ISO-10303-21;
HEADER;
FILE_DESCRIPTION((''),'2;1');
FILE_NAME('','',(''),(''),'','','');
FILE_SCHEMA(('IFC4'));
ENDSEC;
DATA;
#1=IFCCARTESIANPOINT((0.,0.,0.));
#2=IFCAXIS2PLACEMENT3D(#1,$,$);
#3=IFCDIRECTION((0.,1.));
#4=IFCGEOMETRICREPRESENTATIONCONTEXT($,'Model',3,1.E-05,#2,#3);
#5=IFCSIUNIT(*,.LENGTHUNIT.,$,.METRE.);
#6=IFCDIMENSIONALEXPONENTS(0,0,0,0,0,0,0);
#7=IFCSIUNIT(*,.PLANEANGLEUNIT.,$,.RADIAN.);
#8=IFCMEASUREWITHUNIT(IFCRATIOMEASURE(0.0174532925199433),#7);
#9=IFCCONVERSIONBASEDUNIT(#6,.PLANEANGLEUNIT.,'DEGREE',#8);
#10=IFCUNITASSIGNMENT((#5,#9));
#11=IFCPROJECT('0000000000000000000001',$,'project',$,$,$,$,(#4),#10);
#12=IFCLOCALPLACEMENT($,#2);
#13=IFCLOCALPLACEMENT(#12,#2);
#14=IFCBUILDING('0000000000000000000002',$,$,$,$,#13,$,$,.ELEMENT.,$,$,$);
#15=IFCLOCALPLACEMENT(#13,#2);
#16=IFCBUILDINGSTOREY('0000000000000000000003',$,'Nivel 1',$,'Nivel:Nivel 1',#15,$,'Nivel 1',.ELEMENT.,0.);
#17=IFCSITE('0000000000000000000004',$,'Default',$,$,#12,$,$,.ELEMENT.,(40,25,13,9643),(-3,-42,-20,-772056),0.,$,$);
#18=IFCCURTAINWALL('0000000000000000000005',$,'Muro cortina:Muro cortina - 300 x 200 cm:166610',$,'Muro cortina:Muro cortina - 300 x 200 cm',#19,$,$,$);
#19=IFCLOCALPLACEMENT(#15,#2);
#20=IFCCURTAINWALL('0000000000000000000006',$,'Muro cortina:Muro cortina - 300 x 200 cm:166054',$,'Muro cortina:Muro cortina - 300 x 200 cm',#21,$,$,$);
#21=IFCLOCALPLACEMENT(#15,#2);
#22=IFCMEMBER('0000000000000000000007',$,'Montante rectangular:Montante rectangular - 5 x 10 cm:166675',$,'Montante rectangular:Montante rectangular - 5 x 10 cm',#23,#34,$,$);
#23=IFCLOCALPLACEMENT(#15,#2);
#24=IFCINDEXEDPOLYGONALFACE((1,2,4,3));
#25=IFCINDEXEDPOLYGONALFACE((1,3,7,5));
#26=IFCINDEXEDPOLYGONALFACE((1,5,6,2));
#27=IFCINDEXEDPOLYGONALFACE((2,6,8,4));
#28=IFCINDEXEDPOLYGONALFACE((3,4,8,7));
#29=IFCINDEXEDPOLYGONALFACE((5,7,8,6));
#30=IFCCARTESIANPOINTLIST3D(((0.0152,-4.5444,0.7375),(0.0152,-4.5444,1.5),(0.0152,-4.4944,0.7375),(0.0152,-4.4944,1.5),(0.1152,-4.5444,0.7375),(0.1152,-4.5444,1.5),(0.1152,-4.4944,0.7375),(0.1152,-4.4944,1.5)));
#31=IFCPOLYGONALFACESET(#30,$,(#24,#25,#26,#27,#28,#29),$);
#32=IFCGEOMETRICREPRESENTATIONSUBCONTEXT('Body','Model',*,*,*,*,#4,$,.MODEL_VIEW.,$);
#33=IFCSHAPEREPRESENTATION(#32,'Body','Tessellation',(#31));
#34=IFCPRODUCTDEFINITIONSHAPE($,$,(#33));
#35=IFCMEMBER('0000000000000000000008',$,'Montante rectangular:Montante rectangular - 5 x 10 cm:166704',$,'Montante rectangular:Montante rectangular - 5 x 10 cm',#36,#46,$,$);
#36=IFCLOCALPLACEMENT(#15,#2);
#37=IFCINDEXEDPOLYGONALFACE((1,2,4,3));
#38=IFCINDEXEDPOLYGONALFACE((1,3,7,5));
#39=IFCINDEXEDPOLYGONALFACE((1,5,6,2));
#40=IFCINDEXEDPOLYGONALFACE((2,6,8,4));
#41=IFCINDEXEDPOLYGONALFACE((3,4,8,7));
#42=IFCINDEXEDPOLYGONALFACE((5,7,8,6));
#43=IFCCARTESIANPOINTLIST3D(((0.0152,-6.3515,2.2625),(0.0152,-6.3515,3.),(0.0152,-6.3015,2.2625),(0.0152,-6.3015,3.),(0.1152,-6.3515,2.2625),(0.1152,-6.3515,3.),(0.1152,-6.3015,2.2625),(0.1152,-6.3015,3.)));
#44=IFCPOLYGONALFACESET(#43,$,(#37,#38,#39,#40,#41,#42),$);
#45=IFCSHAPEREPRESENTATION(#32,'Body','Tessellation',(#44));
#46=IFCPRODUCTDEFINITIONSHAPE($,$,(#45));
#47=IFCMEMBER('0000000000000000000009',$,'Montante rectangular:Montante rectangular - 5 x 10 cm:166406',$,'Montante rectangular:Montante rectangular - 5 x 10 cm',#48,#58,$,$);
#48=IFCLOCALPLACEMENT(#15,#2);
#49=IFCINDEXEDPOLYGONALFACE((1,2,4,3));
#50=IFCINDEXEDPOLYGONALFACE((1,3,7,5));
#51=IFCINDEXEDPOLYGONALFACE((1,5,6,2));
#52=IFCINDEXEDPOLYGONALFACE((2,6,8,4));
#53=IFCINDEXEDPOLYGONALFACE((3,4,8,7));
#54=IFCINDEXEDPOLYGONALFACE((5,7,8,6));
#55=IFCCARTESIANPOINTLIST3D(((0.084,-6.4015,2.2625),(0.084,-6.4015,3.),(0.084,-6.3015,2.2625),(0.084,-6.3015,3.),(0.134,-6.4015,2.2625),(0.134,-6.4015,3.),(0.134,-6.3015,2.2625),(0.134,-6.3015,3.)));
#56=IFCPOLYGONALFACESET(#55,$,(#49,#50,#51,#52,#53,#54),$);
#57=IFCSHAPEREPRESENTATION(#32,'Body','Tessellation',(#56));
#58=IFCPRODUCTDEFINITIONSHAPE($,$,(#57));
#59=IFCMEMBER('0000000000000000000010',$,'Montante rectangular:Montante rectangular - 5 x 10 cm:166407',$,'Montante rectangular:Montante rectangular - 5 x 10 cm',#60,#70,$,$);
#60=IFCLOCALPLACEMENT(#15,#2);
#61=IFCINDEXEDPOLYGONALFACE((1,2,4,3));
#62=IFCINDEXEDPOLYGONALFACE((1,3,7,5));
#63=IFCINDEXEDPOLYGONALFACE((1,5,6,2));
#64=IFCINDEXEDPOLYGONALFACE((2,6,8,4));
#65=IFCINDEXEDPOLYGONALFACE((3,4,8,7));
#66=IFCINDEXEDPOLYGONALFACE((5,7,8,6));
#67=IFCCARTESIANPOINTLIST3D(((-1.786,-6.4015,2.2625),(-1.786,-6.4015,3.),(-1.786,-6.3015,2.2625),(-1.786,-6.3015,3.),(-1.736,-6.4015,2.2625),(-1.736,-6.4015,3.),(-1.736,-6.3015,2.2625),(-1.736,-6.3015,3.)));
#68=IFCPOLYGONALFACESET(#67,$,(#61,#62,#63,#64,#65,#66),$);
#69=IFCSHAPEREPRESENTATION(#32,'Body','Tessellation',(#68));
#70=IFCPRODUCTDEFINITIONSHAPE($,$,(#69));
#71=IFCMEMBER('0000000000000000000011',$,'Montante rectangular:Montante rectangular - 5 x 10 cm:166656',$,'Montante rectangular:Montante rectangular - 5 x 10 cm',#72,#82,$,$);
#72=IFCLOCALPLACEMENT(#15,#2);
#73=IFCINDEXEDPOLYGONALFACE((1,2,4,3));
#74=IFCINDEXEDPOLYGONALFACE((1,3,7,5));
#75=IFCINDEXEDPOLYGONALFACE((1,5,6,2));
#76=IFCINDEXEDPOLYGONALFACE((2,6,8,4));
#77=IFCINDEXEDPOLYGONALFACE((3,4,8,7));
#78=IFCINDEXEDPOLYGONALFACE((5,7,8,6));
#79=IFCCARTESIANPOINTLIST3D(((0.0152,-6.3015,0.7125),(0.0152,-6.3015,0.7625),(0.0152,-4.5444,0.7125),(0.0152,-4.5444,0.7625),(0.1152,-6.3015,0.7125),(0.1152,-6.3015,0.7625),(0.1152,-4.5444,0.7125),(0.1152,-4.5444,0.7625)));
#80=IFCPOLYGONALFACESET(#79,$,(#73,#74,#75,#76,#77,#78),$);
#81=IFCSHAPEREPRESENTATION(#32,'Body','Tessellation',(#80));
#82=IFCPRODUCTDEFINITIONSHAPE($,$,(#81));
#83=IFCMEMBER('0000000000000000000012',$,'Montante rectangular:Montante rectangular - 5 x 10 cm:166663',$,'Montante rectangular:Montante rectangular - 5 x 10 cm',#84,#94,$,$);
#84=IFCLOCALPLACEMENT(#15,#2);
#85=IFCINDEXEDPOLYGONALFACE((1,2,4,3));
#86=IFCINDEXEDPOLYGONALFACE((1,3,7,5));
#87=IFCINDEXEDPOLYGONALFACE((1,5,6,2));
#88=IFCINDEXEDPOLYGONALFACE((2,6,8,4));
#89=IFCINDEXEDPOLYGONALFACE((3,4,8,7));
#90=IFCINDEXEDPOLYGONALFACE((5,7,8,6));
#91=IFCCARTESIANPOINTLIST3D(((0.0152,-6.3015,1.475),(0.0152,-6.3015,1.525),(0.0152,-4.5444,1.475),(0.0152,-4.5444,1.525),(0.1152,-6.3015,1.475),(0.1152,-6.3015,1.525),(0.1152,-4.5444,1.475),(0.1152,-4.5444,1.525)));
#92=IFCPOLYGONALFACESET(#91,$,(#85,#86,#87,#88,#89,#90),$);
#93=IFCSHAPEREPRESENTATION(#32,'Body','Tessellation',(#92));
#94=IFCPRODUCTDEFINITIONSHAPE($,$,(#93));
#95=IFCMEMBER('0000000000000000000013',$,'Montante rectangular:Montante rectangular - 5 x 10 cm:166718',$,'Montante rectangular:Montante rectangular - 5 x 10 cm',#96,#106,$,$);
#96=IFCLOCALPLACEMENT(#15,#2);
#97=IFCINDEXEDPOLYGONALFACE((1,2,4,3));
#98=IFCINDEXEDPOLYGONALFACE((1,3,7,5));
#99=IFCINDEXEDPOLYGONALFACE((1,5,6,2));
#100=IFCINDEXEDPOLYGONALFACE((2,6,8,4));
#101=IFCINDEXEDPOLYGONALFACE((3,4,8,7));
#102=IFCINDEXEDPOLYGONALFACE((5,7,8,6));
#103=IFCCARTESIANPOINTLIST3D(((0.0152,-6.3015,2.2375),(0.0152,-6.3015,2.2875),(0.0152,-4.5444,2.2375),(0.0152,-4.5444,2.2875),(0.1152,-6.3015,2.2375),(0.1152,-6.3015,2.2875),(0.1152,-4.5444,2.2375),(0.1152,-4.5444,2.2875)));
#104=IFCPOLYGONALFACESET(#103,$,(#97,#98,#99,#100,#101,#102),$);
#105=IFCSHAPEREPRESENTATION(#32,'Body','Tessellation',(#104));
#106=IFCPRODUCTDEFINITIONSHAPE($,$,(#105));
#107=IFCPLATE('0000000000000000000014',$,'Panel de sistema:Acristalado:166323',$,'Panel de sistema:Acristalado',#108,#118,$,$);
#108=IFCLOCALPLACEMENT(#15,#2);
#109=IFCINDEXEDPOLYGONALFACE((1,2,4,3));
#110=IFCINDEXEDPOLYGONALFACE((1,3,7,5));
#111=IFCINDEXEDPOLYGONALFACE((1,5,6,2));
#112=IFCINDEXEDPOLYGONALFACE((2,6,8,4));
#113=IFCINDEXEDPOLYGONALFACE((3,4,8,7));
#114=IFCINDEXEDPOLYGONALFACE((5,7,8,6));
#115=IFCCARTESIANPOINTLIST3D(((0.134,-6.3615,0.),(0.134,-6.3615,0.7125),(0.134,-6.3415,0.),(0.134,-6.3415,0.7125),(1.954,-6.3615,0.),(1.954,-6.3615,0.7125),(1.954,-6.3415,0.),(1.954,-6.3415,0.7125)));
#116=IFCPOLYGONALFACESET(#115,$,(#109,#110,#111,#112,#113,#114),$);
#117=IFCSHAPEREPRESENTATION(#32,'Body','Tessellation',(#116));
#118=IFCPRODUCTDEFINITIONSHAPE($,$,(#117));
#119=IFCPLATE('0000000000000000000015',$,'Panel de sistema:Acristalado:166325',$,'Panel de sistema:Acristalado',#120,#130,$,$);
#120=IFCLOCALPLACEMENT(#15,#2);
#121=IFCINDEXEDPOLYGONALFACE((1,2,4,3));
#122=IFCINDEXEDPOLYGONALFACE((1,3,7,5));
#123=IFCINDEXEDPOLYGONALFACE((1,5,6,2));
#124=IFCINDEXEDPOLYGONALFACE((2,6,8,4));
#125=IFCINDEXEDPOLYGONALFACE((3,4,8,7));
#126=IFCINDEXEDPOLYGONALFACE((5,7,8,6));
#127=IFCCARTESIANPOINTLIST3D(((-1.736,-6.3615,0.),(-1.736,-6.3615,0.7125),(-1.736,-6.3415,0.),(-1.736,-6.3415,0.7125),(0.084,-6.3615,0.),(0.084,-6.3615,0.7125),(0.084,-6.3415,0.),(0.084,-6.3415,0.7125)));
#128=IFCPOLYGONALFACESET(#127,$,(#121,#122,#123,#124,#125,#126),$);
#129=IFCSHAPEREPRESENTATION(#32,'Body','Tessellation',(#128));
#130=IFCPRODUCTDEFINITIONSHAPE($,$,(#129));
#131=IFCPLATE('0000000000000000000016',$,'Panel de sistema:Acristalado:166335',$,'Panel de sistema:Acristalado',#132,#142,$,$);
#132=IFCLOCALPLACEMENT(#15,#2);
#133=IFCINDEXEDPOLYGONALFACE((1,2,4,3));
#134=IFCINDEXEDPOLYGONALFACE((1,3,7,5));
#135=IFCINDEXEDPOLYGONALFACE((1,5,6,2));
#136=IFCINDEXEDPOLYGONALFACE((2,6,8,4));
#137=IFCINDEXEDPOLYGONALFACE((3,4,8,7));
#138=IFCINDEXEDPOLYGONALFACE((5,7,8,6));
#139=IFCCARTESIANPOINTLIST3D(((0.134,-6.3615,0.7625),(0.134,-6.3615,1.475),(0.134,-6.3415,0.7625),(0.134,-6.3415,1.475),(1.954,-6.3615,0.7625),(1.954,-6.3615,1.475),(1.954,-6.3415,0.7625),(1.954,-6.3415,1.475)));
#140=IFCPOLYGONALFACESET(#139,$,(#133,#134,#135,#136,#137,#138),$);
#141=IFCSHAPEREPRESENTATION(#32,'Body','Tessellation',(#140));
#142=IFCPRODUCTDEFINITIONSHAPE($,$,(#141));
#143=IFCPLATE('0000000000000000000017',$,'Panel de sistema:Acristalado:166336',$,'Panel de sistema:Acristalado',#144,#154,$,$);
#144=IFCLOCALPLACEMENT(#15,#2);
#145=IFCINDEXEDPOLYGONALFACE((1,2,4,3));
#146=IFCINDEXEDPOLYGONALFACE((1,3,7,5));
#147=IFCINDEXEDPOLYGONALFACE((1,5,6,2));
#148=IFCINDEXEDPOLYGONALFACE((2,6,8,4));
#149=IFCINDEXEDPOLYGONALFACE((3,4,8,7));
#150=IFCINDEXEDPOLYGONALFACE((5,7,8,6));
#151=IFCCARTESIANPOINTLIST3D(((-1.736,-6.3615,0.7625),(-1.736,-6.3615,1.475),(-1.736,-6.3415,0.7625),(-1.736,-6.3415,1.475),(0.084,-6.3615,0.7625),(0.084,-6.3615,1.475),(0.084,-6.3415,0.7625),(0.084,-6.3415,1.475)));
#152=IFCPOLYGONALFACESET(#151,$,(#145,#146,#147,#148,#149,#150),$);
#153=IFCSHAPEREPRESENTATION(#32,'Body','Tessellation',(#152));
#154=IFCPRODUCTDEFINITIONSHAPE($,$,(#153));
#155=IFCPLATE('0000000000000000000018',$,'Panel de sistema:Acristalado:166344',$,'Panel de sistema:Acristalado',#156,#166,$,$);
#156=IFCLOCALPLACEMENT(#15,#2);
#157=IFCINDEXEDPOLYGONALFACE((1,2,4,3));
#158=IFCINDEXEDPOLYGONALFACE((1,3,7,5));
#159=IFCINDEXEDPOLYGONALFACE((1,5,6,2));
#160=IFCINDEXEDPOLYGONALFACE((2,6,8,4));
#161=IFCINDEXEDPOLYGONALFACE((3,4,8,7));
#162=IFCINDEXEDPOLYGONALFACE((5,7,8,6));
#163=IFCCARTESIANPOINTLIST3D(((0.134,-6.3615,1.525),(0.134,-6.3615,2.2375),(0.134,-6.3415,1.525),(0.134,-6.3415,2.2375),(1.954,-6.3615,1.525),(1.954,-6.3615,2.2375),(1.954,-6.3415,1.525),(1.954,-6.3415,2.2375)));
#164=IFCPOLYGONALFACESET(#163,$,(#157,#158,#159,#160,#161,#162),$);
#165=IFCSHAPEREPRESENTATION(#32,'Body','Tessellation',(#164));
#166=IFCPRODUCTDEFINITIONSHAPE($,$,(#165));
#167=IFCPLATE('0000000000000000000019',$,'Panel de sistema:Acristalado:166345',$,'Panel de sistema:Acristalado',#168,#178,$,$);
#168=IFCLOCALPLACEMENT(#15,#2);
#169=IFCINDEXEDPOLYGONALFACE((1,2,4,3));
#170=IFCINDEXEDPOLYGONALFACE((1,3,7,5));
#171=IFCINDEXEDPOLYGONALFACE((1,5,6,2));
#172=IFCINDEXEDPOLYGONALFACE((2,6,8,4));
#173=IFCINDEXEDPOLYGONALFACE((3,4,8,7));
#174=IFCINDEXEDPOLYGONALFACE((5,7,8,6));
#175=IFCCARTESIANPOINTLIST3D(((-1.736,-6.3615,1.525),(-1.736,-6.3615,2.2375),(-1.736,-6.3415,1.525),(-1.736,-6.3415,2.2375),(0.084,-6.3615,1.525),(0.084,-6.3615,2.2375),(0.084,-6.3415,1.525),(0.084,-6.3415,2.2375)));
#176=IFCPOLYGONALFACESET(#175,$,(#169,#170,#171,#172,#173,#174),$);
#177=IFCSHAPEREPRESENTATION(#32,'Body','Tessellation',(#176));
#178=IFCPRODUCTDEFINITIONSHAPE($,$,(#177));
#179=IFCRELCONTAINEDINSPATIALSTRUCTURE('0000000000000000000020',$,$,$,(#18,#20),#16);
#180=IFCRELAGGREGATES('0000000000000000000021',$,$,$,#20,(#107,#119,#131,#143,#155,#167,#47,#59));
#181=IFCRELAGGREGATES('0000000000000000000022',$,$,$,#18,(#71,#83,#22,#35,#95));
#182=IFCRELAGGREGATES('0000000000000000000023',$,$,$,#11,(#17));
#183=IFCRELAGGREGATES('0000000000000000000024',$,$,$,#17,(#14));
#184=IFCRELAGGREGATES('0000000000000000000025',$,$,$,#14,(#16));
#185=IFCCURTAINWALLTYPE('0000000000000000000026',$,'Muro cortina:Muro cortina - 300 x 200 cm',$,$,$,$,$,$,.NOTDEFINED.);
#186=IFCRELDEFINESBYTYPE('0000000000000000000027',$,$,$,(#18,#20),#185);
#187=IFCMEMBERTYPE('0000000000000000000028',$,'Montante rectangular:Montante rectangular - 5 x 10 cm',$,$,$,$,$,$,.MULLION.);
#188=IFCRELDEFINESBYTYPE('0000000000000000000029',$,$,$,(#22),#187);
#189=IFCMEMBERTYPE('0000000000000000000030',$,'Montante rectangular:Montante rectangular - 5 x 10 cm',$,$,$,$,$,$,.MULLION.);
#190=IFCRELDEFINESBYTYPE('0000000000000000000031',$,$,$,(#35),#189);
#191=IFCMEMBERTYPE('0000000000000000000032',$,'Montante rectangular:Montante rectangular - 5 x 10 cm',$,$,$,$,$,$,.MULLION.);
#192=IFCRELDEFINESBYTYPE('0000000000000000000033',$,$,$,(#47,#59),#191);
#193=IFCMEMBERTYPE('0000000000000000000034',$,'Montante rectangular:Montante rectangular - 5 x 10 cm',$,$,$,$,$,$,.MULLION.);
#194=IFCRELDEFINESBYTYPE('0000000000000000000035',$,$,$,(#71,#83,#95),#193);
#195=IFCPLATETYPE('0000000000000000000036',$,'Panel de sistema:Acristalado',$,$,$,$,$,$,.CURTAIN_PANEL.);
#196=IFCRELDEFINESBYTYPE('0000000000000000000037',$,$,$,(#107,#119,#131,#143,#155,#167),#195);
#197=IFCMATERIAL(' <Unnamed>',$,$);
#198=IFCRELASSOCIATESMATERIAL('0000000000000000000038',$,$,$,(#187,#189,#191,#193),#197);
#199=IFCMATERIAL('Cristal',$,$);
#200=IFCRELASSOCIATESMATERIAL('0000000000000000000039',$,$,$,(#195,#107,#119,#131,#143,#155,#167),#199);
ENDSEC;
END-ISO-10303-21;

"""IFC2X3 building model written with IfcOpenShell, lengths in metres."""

from ifc_helpers import new_model, entity, si_unit, converted_unit, direction, frame, origin, origin_2d_with_axis, place, context, subcontext, project, spatial, rectangle, extrude, source, transform, mapped, material, type_object, type_shapes, element, aggregate, save


model = new_model("IFC2X3")

# Units and contexts
model_context = context("Model", 3, precision=1e-05, world=origin(), true_north=direction((0.0, 1.0)))
body_context = subcontext(model_context, "Body", "Model", "MODEL_VIEW")
ifc_project = project(units=[si_unit("LENGTHUNIT", "METRE"), converted_unit("PLANEANGLEUNIT", "DEGREE", entity("IfcRatioMeasure", 0.0174532925199433), si_unit("PLANEANGLEUNIT", "RADIAN"), dimensions=[0, 0, 0, 0, 0, 0, 0])], contexts=[model_context])

# Site, building, storey
site_placement = place(None, origin())
site = spatial("IfcSite", under=ifc_project, at=site_placement, Name="Default", CompositionType="ELEMENT", RefLatitude=(40, 25, 13, 9643), RefLongitude=(-3, -42, -20, -772056), RefElevation=0.0)
building_placement = place(site_placement, origin())
building = spatial("IfcBuilding", under=site, at=building_placement, CompositionType="ELEMENT")
storey_placement = place(building_placement, origin())
storey = spatial("IfcBuildingStorey", under=building, at=storey_placement, Name="Nivel 1", ObjectType="Nivel:Nivel 1", LongName="Nivel 1", CompositionType="ELEMENT", Elevation=0.0)

# Curtain walls
curtain_wall_type = type_object("IfcCurtainWallType", Name="Muro cortina:Muro cortina - 300 x 200 cm", PredefinedType="NOTDEFINED")
curtain_wall_1_placement = place(storey_placement, origin())
curtain_wall_1 = element("IfcCurtainWall", 1, at=curtain_wall_1_placement, inside=storey, type_object=curtain_wall_type, Name="Muro cortina:Muro cortina - 300 x 200 cm:166610", ObjectType="Muro cortina:Muro cortina - 300 x 200 cm")
ifc_material_1 = material(Name=" <Unnamed>")
curtain_wall_2_placement = place(storey_placement, origin())
curtain_wall_2 = element("IfcCurtainWall", 2, at=curtain_wall_2_placement, inside=storey, type_object=curtain_wall_type, Name="Muro cortina:Muro cortina - 300 x 200 cm:166054", ObjectType="Muro cortina:Muro cortina - 300 x 200 cm")

# Members
member_type_1 = type_object("IfcMemberType", Name="Montante rectangular:Montante rectangular - 5 x 10 cm", PredefinedType="MULLION", material=ifc_material_1)
shared_shape_1 = source(origin(), body_context, "Body", "SweptSolid", [
    extrude(rectangle(XDim=0.1, YDim=0.05, at=origin_2d_with_axis()), frame((0.0, 0.0, -0.7625), z_axis=(0.0, 0.0, 1.0), x_axis=(0.0, -1.0, 0.0)), (0.0, 0.0, 1.0), 0.7625),
])
type_shapes(member_type_1, [shared_shape_1])
member_1_placement = place(storey_placement, frame((0.0652, -4.5194, 0.7375), z_axis=(0.0, 0.0, -1.0), x_axis=(0.0, -1.0, 0.0)))
member_1 = element("IfcMember", 3, at=member_1_placement, type_object=member_type_1, Name="Montante rectangular:Montante rectangular - 5 x 10 cm:166675", ObjectType="Montante rectangular:Montante rectangular - 5 x 10 cm", context=body_context, shape_type="MappedRepresentation", body=[
    mapped(shared_shape_1, transform((0.0, 0.0, 0.0), scale=1.0)),
])
member_type_2 = type_object("IfcMemberType", Name="Montante rectangular:Montante rectangular - 5 x 10 cm", PredefinedType="MULLION", material=ifc_material_1)
shared_shape_2 = source(origin(), body_context, "Body", "SweptSolid", [
    extrude(rectangle(XDim=0.1, YDim=0.05, at=origin_2d_with_axis()), frame((-0.025, 0.0, -0.7375), z_axis=(0.0, 0.0, 1.0), x_axis=(0.0, -1.0, 0.0)), (0.0, 0.0, 1.0), 0.7375),
])
type_shapes(member_type_2, [shared_shape_2])
member_2_placement = place(storey_placement, frame((0.0652, -6.3515, 2.2625), z_axis=(0.0, 0.0, -1.0), x_axis=(0.0, -1.0, 0.0)))
member_2 = element("IfcMember", 4, at=member_2_placement, type_object=member_type_2, Name="Montante rectangular:Montante rectangular - 5 x 10 cm:166704", ObjectType="Montante rectangular:Montante rectangular - 5 x 10 cm", context=body_context, shape_type="MappedRepresentation", body=[
    mapped(shared_shape_2, transform((0.0, 0.0, 0.0), scale=1.0)),
])
member_type_3 = type_object("IfcMemberType", Name="Montante rectangular:Montante rectangular - 5 x 10 cm", PredefinedType="MULLION", material=ifc_material_1)
shared_shape_3 = source(origin(), body_context, "Body", "SweptSolid", [
    extrude(rectangle(XDim=0.1, YDim=0.05, at=origin_2d_with_axis()), frame((0.0, 0.0, -0.7375), z_axis=(0.0, 0.0, 1.0), x_axis=(0.0, -1.0, 0.0)), (0.0, 0.0, 1.0), 0.7375),
])
type_shapes(member_type_3, [shared_shape_3])
member_3_placement = place(storey_placement, frame((0.109, -6.3515, 2.2625), z_axis=(0.0, 0.0, -1.0), x_axis=(-1.0, 0.0, 0.0)))
member_3 = element("IfcMember", 5, at=member_3_placement, type_object=member_type_3, Name="Montante rectangular:Montante rectangular - 5 x 10 cm:166406", ObjectType="Montante rectangular:Montante rectangular - 5 x 10 cm", context=body_context, shape_type="MappedRepresentation", body=[
    mapped(shared_shape_3, transform((0.0, 0.0, 0.0), scale=1.0)),
])
member_4_placement = place(storey_placement, frame((-1.761, -6.3515, 2.2625), z_axis=(0.0, 0.0, -1.0), x_axis=(-1.0, 0.0, 0.0)))
member_4 = element("IfcMember", 6, at=member_4_placement, type_object=member_type_3, Name="Montante rectangular:Montante rectangular - 5 x 10 cm:166407", ObjectType="Montante rectangular:Montante rectangular - 5 x 10 cm", context=body_context, shape_type="MappedRepresentation", body=[
    mapped(shared_shape_3, transform((0.0, 0.0, 0.0), scale=1.0)),
])
member_type_4 = type_object("IfcMemberType", Name="Montante rectangular:Montante rectangular - 5 x 10 cm", PredefinedType="MULLION", material=ifc_material_1)
shared_shape_4 = source(origin(), body_context, "Body", "SweptSolid", [
    extrude(rectangle(XDim=0.1, YDim=0.05, at=origin_2d_with_axis()), frame((0.0, 0.0, -1.7571), z_axis=(0.0, 0.0, 1.0), x_axis=(0.0, -1.0, 0.0)), (0.0, 0.0, 1.0), 1.7571),
])
type_shapes(member_type_4, [shared_shape_4])
member_5_placement = place(storey_placement, frame((0.0652, -6.3015, 0.7375), z_axis=(0.0, -1.0, 0.0), x_axis=(0.0, 0.0, 1.0)))
member_5 = element("IfcMember", 7, at=member_5_placement, type_object=member_type_4, Name="Montante rectangular:Montante rectangular - 5 x 10 cm:166656", ObjectType="Montante rectangular:Montante rectangular - 5 x 10 cm", context=body_context, shape_type="MappedRepresentation", body=[
    mapped(shared_shape_4, transform((0.0, 0.0, 0.0), scale=1.0)),
])
member_6_placement = place(storey_placement, frame((0.0652, -6.3015, 1.5), z_axis=(0.0, -1.0, 0.0), x_axis=(0.0, 0.0, 1.0)))
member_6 = element("IfcMember", 8, at=member_6_placement, type_object=member_type_4, Name="Montante rectangular:Montante rectangular - 5 x 10 cm:166663", ObjectType="Montante rectangular:Montante rectangular - 5 x 10 cm", context=body_context, shape_type="MappedRepresentation", body=[
    mapped(shared_shape_4, transform((0.0, 0.0, 0.0), scale=1.0)),
])
member_7_placement = place(storey_placement, frame((0.0652, -6.3015, 2.2625), z_axis=(0.0, -1.0, 0.0), x_axis=(0.0, 0.0, 1.0)))
member_7 = element("IfcMember", 9, at=member_7_placement, type_object=member_type_4, Name="Montante rectangular:Montante rectangular - 5 x 10 cm:166718", ObjectType="Montante rectangular:Montante rectangular - 5 x 10 cm", context=body_context, shape_type="MappedRepresentation", body=[
    mapped(shared_shape_4, transform((0.0, 0.0, 0.0), scale=1.0)),
])

# Plates
ifc_material_2 = material(Name="Cristal")
plate_type_1 = type_object("IfcPlateType", Name="Panel de sistema:Acristalado", PredefinedType="CURTAIN_PANEL", material=ifc_material_2)
shared_shape_5 = source(origin(), body_context, "Body", "SweptSolid", [
    extrude(rectangle(XDim=0.02, YDim=1.82, at=origin_2d_with_axis()), frame((0.0, 0.0, 0.0), z_axis=(0.0, 0.0, 1.0), x_axis=(0.0, 1.0, 0.0)), (0.0, 0.0, 1.0), 0.7125),
])
type_shapes(plate_type_1, [shared_shape_5])
plate_1_placement = place(curtain_wall_2_placement, frame((1.044, -6.3515, 0.0), z_axis=(0.0, 0.0, 1.0), x_axis=(-1.0, 0.0, 0.0)))
plate_1 = element("IfcPlate", 10, at=plate_1_placement, type_object=plate_type_1, material=ifc_material_2, Name="Panel de sistema:Acristalado:166323", ObjectType="Panel de sistema:Acristalado", context=body_context, shape_type="MappedRepresentation", body=[
    mapped(shared_shape_5, transform((0.0, 0.0, 0.0), scale=1.0)),
])
plate_2_placement = place(curtain_wall_2_placement, frame((-0.826, -6.3515, 0.0), z_axis=(0.0, 0.0, 1.0), x_axis=(-1.0, 0.0, 0.0)))
plate_2 = element("IfcPlate", 11, at=plate_2_placement, type_object=plate_type_1, material=ifc_material_2, Name="Panel de sistema:Acristalado:166325", ObjectType="Panel de sistema:Acristalado", context=body_context, shape_type="MappedRepresentation", body=[
    mapped(shared_shape_5, transform((0.0, 0.0, 0.0), scale=1.0)),
])
plate_3_placement = place(curtain_wall_2_placement, frame((1.044, -6.3515, 0.7625), z_axis=(0.0, 0.0, 1.0), x_axis=(-1.0, 0.0, 0.0)))
plate_3 = element("IfcPlate", 12, at=plate_3_placement, type_object=plate_type_1, material=ifc_material_2, Name="Panel de sistema:Acristalado:166335", ObjectType="Panel de sistema:Acristalado", context=body_context, shape_type="MappedRepresentation", body=[
    mapped(shared_shape_5, transform((0.0, 0.0, 0.0), scale=1.0)),
])
plate_4_placement = place(curtain_wall_2_placement, frame((-0.826, -6.3515, 0.7625), z_axis=(0.0, 0.0, 1.0), x_axis=(-1.0, 0.0, 0.0)))
plate_4 = element("IfcPlate", 13, at=plate_4_placement, type_object=plate_type_1, material=ifc_material_2, Name="Panel de sistema:Acristalado:166336", ObjectType="Panel de sistema:Acristalado", context=body_context, shape_type="MappedRepresentation", body=[
    mapped(shared_shape_5, transform((0.0, 0.0, 0.0), scale=1.0)),
])
plate_5_placement = place(curtain_wall_2_placement, frame((1.044, -6.3515, 1.525), z_axis=(0.0, 0.0, 1.0), x_axis=(-1.0, 0.0, 0.0)))
plate_5 = element("IfcPlate", 14, at=plate_5_placement, type_object=plate_type_1, material=ifc_material_2, Name="Panel de sistema:Acristalado:166344", ObjectType="Panel de sistema:Acristalado", context=body_context, shape_type="MappedRepresentation", body=[
    mapped(shared_shape_5, transform((0.0, 0.0, 0.0), scale=1.0)),
])
plate_6_placement = place(curtain_wall_2_placement, frame((-0.826, -6.3515, 1.525), z_axis=(0.0, 0.0, 1.0), x_axis=(-1.0, 0.0, 0.0)))
plate_6 = element("IfcPlate", 15, at=plate_6_placement, type_object=plate_type_1, material=ifc_material_2, Name="Panel de sistema:Acristalado:166345", ObjectType="Panel de sistema:Acristalado", context=body_context, shape_type="MappedRepresentation", body=[
    mapped(shared_shape_5, transform((0.0, 0.0, 0.0), scale=1.0)),
])
aggregate(curtain_wall_2, [plate_1, plate_2, plate_3, plate_4, plate_5, plate_6, member_3, member_4])
aggregate(curtain_wall_1, [member_5, member_6, member_1, member_2, member_7])

save(model, "model.ifc")
